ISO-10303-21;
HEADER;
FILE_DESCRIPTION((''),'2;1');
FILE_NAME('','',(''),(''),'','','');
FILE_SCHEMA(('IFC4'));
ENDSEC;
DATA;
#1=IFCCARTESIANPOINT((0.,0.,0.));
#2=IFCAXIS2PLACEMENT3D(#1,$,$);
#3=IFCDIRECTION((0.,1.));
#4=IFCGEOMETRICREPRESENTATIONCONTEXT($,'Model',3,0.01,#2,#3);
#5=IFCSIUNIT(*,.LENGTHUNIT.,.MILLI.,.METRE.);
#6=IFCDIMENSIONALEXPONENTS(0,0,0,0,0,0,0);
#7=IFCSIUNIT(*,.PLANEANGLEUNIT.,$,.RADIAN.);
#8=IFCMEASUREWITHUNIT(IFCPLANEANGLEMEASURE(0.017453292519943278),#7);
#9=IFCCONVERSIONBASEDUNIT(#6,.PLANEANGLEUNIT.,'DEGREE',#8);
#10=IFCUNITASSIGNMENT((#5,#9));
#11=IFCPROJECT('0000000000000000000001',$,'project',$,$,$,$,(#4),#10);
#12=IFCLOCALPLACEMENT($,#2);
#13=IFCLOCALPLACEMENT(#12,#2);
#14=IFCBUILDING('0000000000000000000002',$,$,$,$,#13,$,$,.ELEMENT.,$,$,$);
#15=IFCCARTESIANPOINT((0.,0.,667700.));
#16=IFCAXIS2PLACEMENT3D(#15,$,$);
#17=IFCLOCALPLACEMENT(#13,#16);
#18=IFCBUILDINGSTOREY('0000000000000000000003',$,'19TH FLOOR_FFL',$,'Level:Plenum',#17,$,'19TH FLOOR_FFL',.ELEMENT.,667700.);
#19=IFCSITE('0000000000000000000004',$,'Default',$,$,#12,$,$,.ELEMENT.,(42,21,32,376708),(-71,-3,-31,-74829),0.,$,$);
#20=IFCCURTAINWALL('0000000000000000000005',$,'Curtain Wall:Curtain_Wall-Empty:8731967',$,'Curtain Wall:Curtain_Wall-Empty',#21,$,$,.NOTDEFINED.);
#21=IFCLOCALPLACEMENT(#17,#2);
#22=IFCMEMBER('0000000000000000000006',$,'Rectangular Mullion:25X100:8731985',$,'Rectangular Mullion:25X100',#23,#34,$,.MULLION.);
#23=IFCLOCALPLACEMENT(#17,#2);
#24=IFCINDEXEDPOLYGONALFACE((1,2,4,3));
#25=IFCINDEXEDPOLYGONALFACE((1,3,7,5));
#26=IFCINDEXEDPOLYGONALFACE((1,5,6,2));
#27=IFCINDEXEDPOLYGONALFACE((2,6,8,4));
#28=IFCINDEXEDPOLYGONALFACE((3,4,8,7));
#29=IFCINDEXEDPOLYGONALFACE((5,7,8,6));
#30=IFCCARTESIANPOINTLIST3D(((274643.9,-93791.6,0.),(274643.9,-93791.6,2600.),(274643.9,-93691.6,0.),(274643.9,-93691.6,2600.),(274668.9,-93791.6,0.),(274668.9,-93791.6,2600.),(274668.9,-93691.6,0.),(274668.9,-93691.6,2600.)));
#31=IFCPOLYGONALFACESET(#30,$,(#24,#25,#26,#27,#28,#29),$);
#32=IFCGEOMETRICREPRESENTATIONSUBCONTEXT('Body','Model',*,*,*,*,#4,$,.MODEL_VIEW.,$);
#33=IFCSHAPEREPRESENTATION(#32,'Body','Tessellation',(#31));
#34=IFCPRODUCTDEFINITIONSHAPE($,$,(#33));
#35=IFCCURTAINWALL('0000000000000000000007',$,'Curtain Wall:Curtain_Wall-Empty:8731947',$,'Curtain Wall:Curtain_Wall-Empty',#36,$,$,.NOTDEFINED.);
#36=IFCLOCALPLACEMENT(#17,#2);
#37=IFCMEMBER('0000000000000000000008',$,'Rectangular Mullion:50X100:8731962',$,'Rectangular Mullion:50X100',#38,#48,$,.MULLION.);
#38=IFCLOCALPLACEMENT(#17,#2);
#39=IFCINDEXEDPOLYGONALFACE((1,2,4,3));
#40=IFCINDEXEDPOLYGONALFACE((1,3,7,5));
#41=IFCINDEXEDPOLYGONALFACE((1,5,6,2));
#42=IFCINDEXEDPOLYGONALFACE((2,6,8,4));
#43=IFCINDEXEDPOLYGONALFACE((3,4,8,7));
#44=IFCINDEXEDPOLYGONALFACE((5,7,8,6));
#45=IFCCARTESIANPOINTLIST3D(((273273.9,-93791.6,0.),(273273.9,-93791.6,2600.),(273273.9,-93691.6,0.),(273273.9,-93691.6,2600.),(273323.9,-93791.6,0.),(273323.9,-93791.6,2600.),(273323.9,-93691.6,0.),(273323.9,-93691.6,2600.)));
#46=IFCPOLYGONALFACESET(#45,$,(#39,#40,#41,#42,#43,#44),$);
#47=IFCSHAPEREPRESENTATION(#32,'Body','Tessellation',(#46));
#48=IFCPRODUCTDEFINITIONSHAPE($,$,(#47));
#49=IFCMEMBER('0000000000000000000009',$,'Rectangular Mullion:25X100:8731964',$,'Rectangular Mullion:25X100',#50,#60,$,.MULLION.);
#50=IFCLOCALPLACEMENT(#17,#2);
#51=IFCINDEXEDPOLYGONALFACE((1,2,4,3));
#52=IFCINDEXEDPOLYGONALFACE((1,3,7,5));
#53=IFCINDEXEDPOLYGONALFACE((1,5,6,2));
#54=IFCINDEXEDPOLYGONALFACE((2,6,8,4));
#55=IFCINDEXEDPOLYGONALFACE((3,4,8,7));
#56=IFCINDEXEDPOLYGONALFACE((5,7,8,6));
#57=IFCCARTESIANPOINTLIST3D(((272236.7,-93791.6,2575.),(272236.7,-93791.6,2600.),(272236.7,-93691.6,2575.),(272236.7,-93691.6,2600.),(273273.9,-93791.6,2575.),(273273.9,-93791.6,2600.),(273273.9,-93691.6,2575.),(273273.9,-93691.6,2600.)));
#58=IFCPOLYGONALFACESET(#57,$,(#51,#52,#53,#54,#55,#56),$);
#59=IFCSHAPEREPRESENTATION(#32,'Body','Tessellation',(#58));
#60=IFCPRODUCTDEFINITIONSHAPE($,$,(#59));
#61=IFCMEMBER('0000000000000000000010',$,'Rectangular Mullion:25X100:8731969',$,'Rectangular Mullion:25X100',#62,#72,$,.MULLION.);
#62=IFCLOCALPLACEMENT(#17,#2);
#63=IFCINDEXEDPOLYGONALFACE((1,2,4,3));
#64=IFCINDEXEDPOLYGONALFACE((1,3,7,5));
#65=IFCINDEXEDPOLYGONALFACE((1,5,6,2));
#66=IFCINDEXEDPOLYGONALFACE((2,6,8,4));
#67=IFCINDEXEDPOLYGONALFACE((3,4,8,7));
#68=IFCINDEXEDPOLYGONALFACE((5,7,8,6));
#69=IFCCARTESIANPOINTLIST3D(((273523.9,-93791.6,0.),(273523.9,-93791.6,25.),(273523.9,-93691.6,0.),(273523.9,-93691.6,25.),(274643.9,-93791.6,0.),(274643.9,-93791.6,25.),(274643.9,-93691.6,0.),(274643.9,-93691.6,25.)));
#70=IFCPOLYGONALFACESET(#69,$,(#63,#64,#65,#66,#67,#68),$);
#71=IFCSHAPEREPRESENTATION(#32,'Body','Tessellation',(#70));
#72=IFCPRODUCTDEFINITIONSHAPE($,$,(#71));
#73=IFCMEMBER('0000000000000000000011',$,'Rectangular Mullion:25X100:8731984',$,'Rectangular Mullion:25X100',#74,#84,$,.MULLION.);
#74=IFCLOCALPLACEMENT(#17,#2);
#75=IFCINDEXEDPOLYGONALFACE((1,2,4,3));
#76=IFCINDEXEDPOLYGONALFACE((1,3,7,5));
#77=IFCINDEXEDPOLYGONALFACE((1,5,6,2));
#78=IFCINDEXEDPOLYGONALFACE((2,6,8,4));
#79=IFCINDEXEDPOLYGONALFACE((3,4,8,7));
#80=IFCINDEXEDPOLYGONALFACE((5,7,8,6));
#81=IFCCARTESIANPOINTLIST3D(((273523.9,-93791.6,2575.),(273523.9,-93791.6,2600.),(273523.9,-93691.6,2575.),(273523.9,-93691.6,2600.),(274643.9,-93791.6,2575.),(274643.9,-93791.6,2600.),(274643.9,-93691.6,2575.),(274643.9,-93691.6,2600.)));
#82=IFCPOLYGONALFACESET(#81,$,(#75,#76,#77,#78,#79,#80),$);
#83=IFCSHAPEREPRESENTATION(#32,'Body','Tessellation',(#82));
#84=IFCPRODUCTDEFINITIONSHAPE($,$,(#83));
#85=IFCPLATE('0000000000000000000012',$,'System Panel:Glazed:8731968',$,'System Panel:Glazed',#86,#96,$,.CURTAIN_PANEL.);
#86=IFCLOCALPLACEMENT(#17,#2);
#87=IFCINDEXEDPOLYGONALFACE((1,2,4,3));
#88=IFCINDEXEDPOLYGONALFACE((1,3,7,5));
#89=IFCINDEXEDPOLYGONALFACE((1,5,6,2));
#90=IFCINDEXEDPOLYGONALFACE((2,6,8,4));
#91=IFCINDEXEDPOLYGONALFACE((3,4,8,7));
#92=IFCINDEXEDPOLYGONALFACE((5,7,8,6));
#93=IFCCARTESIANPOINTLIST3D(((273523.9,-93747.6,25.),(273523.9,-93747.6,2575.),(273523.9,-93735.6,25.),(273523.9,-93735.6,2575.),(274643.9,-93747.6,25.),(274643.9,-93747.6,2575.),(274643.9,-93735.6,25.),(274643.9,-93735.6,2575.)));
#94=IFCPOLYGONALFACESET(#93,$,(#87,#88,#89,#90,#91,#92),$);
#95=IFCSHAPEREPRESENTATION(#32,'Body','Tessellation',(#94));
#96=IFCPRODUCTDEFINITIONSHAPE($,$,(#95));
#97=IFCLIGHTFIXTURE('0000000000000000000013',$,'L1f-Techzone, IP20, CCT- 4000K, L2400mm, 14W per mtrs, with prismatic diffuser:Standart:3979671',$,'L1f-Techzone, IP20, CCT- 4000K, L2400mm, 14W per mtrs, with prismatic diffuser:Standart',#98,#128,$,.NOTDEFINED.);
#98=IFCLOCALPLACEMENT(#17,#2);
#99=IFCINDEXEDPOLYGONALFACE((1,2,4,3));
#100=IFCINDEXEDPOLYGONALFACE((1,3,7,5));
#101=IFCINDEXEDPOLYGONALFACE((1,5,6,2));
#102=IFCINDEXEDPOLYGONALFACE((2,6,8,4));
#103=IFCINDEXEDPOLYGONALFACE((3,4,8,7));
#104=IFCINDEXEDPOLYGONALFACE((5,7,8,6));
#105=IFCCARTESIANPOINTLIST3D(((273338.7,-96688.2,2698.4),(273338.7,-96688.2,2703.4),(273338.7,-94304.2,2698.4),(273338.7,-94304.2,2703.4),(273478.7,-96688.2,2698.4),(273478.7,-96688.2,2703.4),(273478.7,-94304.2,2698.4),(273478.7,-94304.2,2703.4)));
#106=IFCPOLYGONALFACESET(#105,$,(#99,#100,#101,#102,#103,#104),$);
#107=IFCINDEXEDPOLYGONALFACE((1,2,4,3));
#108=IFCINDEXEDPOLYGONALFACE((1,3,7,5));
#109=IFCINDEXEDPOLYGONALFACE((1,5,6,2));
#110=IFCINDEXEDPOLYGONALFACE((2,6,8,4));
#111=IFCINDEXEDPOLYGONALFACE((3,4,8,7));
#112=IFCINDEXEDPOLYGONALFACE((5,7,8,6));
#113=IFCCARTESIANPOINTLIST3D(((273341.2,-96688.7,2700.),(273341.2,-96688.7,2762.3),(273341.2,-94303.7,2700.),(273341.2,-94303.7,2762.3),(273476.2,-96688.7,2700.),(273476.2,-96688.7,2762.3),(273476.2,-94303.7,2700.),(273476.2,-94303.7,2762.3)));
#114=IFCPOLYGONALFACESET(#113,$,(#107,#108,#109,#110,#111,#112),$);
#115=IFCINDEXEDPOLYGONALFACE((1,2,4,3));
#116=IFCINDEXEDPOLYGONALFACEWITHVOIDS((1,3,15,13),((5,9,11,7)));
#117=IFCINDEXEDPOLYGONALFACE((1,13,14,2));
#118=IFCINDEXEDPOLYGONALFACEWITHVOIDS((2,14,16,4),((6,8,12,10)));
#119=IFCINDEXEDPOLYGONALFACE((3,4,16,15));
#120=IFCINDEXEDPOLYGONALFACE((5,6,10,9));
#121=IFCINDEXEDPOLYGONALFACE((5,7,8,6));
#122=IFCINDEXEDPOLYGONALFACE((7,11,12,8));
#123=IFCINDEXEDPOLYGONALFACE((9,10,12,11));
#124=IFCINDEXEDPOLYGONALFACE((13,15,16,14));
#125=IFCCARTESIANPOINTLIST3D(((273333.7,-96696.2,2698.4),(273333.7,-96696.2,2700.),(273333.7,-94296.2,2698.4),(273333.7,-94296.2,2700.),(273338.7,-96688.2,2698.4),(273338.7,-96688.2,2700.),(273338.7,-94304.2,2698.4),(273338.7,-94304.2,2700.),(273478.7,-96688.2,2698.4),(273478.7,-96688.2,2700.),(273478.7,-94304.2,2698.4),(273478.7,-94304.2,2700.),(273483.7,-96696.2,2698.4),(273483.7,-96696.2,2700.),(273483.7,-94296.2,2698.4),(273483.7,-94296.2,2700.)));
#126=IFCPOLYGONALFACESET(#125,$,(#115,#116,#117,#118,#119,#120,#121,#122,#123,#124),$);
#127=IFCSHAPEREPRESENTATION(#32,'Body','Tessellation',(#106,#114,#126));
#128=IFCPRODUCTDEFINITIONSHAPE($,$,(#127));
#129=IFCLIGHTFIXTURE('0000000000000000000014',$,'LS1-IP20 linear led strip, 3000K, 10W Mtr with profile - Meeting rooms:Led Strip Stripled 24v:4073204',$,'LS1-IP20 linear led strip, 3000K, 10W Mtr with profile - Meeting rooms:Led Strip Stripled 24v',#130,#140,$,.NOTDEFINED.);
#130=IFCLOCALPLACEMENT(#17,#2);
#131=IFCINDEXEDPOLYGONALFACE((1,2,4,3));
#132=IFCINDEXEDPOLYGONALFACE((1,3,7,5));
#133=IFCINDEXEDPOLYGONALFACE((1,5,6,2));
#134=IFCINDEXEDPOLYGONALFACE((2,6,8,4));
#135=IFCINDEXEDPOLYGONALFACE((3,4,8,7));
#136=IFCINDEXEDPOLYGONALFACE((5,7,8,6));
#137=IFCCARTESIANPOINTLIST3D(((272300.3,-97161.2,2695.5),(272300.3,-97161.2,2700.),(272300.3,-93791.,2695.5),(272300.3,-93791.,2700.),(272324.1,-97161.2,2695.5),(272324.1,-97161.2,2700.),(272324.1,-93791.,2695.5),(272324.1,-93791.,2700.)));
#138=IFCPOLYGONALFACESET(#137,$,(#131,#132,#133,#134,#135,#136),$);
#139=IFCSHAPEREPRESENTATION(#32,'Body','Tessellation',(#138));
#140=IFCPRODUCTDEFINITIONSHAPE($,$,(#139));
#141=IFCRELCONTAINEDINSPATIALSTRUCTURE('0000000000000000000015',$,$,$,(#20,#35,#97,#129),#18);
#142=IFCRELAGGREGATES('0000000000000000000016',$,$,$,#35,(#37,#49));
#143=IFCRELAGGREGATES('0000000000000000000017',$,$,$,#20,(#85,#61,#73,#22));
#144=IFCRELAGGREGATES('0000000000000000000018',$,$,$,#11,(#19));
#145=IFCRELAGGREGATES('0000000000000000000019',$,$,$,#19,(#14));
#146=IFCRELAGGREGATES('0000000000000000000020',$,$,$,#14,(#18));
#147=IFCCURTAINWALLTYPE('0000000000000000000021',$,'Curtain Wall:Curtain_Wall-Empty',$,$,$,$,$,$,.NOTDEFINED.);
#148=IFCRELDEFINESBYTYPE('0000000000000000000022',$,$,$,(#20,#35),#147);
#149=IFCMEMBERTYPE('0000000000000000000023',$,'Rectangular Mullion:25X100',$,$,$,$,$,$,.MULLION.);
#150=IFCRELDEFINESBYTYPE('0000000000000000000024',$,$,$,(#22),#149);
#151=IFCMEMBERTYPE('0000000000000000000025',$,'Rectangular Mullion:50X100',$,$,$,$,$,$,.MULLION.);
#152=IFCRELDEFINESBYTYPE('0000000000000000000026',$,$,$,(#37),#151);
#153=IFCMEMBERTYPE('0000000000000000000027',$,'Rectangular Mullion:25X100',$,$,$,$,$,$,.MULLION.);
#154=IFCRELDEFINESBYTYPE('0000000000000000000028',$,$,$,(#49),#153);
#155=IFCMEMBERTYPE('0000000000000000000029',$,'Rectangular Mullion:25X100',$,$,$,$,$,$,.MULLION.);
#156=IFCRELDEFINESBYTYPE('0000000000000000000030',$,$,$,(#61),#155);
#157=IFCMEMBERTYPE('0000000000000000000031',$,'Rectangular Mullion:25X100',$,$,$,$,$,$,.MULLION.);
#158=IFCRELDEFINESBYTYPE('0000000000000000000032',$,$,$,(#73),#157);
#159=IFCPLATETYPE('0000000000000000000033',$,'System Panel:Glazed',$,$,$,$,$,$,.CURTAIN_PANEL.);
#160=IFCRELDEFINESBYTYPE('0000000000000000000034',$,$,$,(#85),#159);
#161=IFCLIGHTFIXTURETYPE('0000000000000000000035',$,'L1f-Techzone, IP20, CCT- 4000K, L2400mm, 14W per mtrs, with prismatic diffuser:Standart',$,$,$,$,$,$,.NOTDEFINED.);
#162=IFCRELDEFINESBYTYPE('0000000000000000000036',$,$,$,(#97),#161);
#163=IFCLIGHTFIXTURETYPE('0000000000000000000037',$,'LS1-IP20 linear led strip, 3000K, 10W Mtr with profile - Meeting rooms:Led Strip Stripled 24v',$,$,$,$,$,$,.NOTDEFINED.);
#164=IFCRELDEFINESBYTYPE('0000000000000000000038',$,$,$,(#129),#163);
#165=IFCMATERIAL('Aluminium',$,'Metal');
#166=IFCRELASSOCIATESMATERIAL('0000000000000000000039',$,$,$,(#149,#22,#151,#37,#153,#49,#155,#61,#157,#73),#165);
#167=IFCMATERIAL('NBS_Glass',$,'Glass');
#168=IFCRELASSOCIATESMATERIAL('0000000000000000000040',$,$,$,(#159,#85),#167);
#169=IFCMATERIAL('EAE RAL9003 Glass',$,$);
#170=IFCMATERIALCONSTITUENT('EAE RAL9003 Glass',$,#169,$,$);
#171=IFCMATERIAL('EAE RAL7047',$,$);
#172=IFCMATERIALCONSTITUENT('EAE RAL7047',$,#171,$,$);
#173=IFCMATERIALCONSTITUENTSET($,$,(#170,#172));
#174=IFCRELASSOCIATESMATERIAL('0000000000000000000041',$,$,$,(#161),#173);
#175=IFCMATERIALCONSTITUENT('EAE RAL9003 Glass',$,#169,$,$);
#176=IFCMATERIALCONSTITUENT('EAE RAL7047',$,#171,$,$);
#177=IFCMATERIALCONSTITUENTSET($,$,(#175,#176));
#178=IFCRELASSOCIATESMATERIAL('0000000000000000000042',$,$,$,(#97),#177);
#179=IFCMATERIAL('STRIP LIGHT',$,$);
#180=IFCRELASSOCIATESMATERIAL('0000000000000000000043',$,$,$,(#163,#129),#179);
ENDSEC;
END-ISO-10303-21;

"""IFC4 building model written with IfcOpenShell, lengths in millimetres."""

from ifc_helpers import new_model, entity, si_unit, converted_unit, direction, frame, origin, place, context, subcontext, project, spatial, indexed_curve, outline, extrude, source, transform, mapped, material, constituent, constituent_set, type_object, type_shapes, element, aggregate, save


model = new_model("IFC4")

# Units and contexts
model_context = context("Model", 3, precision=0.01, world=origin(), true_north=direction((0.0, 1.0)))
body_context = subcontext(model_context, "Body", "Model", "MODEL_VIEW")
ifc_project = project(units=[si_unit("LENGTHUNIT", "METRE", prefix="MILLI"), converted_unit("PLANEANGLEUNIT", "DEGREE", entity("IfcPlaneAngleMeasure", 0.017453292519943278), si_unit("PLANEANGLEUNIT", "RADIAN"), dimensions=[0, 0, 0, 0, 0, 0, 0])], contexts=[model_context])

# Site, building, storey
site_placement = place(None, origin())
site = spatial("IfcSite", under=ifc_project, at=site_placement, Name="Default", CompositionType="ELEMENT", RefLatitude=(42, 21, 32, 376708), RefLongitude=(-71, -3, -31, -74829), RefElevation=0.0)
building_placement = place(site_placement, origin())
building = spatial("IfcBuilding", under=site, at=building_placement, CompositionType="ELEMENT")
storey_placement = place(building_placement, frame((0.0, 0.0, 667700.0)))
storey = spatial("IfcBuildingStorey", under=building, at=storey_placement, Name="19TH FLOOR_FFL", ObjectType="Level:Plenum", LongName="19TH FLOOR_FFL", CompositionType="ELEMENT", Elevation=667700.0)

# Curtain wall, member
curtain_wall_type = type_object("IfcCurtainWallType", Name="Curtain Wall:Curtain_Wall-Empty", PredefinedType="NOTDEFINED")
curtain_wall_1_placement = place(storey_placement, frame((0.0, 0.0, -667700.0)))
curtain_wall_1 = element("IfcCurtainWall", 1, at=curtain_wall_1_placement, inside=storey, type_object=curtain_wall_type, Name="Curtain Wall:Curtain_Wall-Empty:8731967", ObjectType="Curtain Wall:Curtain_Wall-Empty", PredefinedType="NOTDEFINED")
ifc_material_1 = material(Name="Aluminium", Category="Metal")
member_type_1 = type_object("IfcMemberType", Name="Rectangular Mullion:25X100", PredefinedType="MULLION", material=ifc_material_1)
shared_shape_1 = source(origin(), body_context, "Body", "SweptSolid", [
    extrude(outline(indexed_curve([(-12.5, -50.0), (12.5, -50.0), (12.5, 50.0), (-12.5, 50.0), (-12.5, -50.0)], self_intersect=False)), frame((-12.5, 0.0, -2600.0), z_axis=(0.0, 0.0, 1.0), x_axis=(-1.0, 0.0, 0.0)), (0.0, 0.0, 1.0), 2600.0),
])
type_shapes(member_type_1, [shared_shape_1])
member_1_placement = place(curtain_wall_1_placement, frame((274668.9, -93741.6, 670300.0)))
member_1 = element("IfcMember", 2, at=member_1_placement, type_object=member_type_1, material=ifc_material_1, Name="Rectangular Mullion:25X100:8731985", ObjectType="Rectangular Mullion:25X100", PredefinedType="MULLION", context=body_context, shape_type="MappedRepresentation", body=[
    mapped(shared_shape_1, transform((0.0, 0.0, 0.0), scale=1.0)),
])

# Curtain wall, members
curtain_wall_2_placement = place(storey_placement, frame((0.0, 0.0, -667700.0)))
curtain_wall_2 = element("IfcCurtainWall", 3, at=curtain_wall_2_placement, inside=storey, type_object=curtain_wall_type, Name="Curtain Wall:Curtain_Wall-Empty:8731947", ObjectType="Curtain Wall:Curtain_Wall-Empty", PredefinedType="NOTDEFINED")
member_type_2 = type_object("IfcMemberType", Name="Rectangular Mullion:50X100", PredefinedType="MULLION", material=ifc_material_1)
shared_shape_2 = source(origin(), body_context, "Body", "SweptSolid", [
    extrude(outline(indexed_curve([(-25.0, -50.0), (25.0, -50.0), (25.0, 50.0), (-25.0, 50.0), (-25.0, -50.0)], self_intersect=False)), frame((-25.0, 0.0, -2600.0), z_axis=(0.0, 0.0, 1.0), x_axis=(-1.0, 0.0, 0.0)), (0.0, 0.0, 1.0), 2600.0),
])
type_shapes(member_type_2, [shared_shape_2])
member_2_placement = place(curtain_wall_2_placement, frame((273323.9, -93741.6, 670300.0)))
member_2 = element("IfcMember", 4, at=member_2_placement, type_object=member_type_2, material=ifc_material_1, Name="Rectangular Mullion:50X100:8731962", ObjectType="Rectangular Mullion:50X100", PredefinedType="MULLION", context=body_context, shape_type="MappedRepresentation", body=[
    mapped(shared_shape_2, transform((0.0, 0.0, 0.0), scale=1.0)),
])
member_type_3 = type_object("IfcMemberType", Name="Rectangular Mullion:25X100", PredefinedType="MULLION", material=ifc_material_1)
shared_shape_3 = source(origin(), body_context, "Body", "SweptSolid", [
    extrude(outline(indexed_curve([(-12.5, -50.0), (12.5, -50.0), (12.5, 50.0), (-12.5, 50.0), (-12.5, -50.0)], self_intersect=False)), frame((-12.5, 0.0, -1037.2), z_axis=(0.0, 0.0, 1.0), x_axis=(-1.0, 0.0, 0.0)), (0.0, 0.0, 1.0), 1037.2),
])
type_shapes(member_type_3, [shared_shape_3])
member_3_placement = place(curtain_wall_2_placement, frame((272236.7, -93741.6, 670300.0), z_axis=(-1.0, 0.0, 0.0), x_axis=(0.0, 0.0, 1.0)))
member_3 = element("IfcMember", 5, at=member_3_placement, type_object=member_type_3, material=ifc_material_1, Name="Rectangular Mullion:25X100:8731964", ObjectType="Rectangular Mullion:25X100", PredefinedType="MULLION", context=body_context, shape_type="MappedRepresentation", body=[
    mapped(shared_shape_3, transform((0.0, 0.0, 0.0), scale=1.0)),
])
aggregate(curtain_wall_2, [member_2, member_3])

# Members
member_type_4 = type_object("IfcMemberType", Name="Rectangular Mullion:25X100", PredefinedType="MULLION", material=ifc_material_1)
shared_shape_4 = source(origin(), body_context, "Body", "SweptSolid", [
    extrude(outline(indexed_curve([(-12.5, -50.0), (12.5, -50.0), (12.5, 50.0), (-12.5, 50.0), (-12.5, -50.0)], self_intersect=False)), frame((-12.5, 0.0, -1120.0), z_axis=(0.0, 0.0, 1.0), x_axis=(-1.0, 0.0, 0.0)), (0.0, 0.0, 1.0), 1120.0),
])
type_shapes(member_type_4, [shared_shape_4])
member_4_placement = place(curtain_wall_1_placement, frame((274643.9, -93741.6, 667700.0), z_axis=(1.0, 0.0, 0.0), x_axis=(0.0, 0.0, -1.0)))
member_4 = element("IfcMember", 6, at=member_4_placement, type_object=member_type_4, material=ifc_material_1, Name="Rectangular Mullion:25X100:8731969", ObjectType="Rectangular Mullion:25X100", PredefinedType="MULLION", context=body_context, shape_type="MappedRepresentation", body=[
    mapped(shared_shape_4, transform((0.0, 0.0, 0.0), scale=1.0)),
])
member_type_5 = type_object("IfcMemberType", Name="Rectangular Mullion:25X100", PredefinedType="MULLION", material=ifc_material_1)
shared_shape_5 = source(origin(), body_context, "Body", "SweptSolid", [
    extrude(outline(indexed_curve([(-12.5, -50.0), (12.5, -50.0), (12.5, 50.0), (-12.5, 50.0), (-12.5, -50.0)], self_intersect=False)), frame((-12.5, 0.0, -1120.0), z_axis=(0.0, 0.0, 1.0), x_axis=(-1.0, 0.0, 0.0)), (0.0, 0.0, 1.0), 1120.0),
])
type_shapes(member_type_5, [shared_shape_5])
member_5_placement = place(curtain_wall_1_placement, frame((273523.9, -93741.6, 670300.0), z_axis=(-1.0, 0.0, 0.0), x_axis=(0.0, 0.0, 1.0)))
member_5 = element("IfcMember", 7, at=member_5_placement, type_object=member_type_5, material=ifc_material_1, Name="Rectangular Mullion:25X100:8731984", ObjectType="Rectangular Mullion:25X100", PredefinedType="MULLION", context=body_context, shape_type="MappedRepresentation", body=[
    mapped(shared_shape_5, transform((0.0, 0.0, 0.0), scale=1.0)),
])

# Plate
ifc_material_2 = material(Name="NBS_Glass", Category="Glass")
plate_type = type_object("IfcPlateType", Name="System Panel:Glazed", PredefinedType="CURTAIN_PANEL", material=ifc_material_2)
shared_shape_6 = source(origin(), body_context, "Body", "SweptSolid", [
    extrude(outline(indexed_curve([(-6.0, -560.0), (6.0, -560.0), (6.0, 560.0), (-6.0, 560.0), (-6.0, -560.0)], self_intersect=False)), frame((0.0, 0.0, 0.0), z_axis=(0.0, 0.0, 1.0), x_axis=(0.0, 1.0, 0.0)), (0.0, 0.0, 1.0), 2550.0),
])
type_shapes(plate_type, [shared_shape_6])
plate_placement = place(curtain_wall_1_placement, frame((274083.9, -93741.6, 667725.0), z_axis=(0.0, 0.0, 1.0), x_axis=(-1.0, 0.0, 0.0)))
plate = element("IfcPlate", 8, at=plate_placement, type_object=plate_type, material=ifc_material_2, Name="System Panel:Glazed:8731968", ObjectType="System Panel:Glazed", PredefinedType="CURTAIN_PANEL", context=body_context, shape_type="MappedRepresentation", body=[
    mapped(shared_shape_6, transform((0.0, 0.0, 0.0), scale=1.0)),
])
aggregate(curtain_wall_1, [plate, member_4, member_5, member_1])

# Light fixtures
ifc_material_3 = material(Name="EAE RAL9003 Glass")
ifc_constituent_1 = constituent(ifc_material_3, Name="EAE RAL9003 Glass")
ifc_material_4 = material(Name="EAE RAL7047")
ifc_constituent_2 = constituent(ifc_material_4, Name="EAE RAL7047")
ifc_constituent_set_1 = constituent_set(constituents=[ifc_constituent_1, ifc_constituent_2])
ifc_constituent_3 = constituent(ifc_material_3, Name="EAE RAL9003 Glass")
ifc_constituent_4 = constituent(ifc_material_4, Name="EAE RAL7047")
ifc_constituent_set_2 = constituent_set(constituents=[ifc_constituent_3, ifc_constituent_4])
light_fixture_type_1 = type_object("IfcLightFixtureType", Name="L1f-Techzone, IP20, CCT- 4000K, L2400mm, 14W per mtrs, with prismatic diffuser:Standart", PredefinedType="NOTDEFINED", material=ifc_constituent_set_2)
shared_shape_7 = source(origin(), body_context, "Body", "SweptSolid", [
    extrude(outline(indexed_curve([(-70.0, -1192.0), (70.0, -1192.0), (70.0, 1192.0), (-70.0, 1192.0), (-70.0, -1192.0)], self_intersect=False)), frame((0.0, 0.0, -3.4), z_axis=(0.0, 0.0, 1.0), x_axis=(-1.0, 0.0, 0.0)), (0.0, 0.0, 1.0), 5.0),
    extrude(outline(indexed_curve([(-67.5, -1192.5), (67.5, -1192.5), (67.5, 1192.5), (-67.5, 1192.5), (-67.5, -1192.5)], self_intersect=False)), frame((0.0, 0.0, -62.3), z_axis=(0.0, 0.0, 1.0), x_axis=(-1.0, 0.0, 0.0)), (0.0, 0.0, 1.0), 62.3),
    extrude(outline(indexed_curve([(-75.0, -1200.0), (75.0, -1200.0), (75.0, 1200.0), (-75.0, 1200.0), (-75.0, -1200.0)], self_intersect=False), holes=[indexed_curve([(-70.0, -1192.0), (-70.0, 1192.0), (70.0, 1192.0), (70.0, -1192.0), (-70.0, -1192.0)], self_intersect=False)]), frame((0.0, 0.0, 0.0), z_axis=(0.0, 0.0, 1.0), x_axis=(-1.0, 0.0, 0.0)), (0.0, 0.0, 1.0), 1.6),
])
type_shapes(light_fixture_type_1, [shared_shape_7])
light_fixture_1_placement = place(storey_placement, frame((273408.7, -95496.2, 2700.0), z_axis=(0.0, 0.0, -1.0), x_axis=(-1.0, 0.0, 0.0)))
element("IfcLightFixture", 9, at=light_fixture_1_placement, inside=storey, type_object=light_fixture_type_1, material=ifc_constituent_set_1, Name="L1f-Techzone, IP20, CCT- 4000K, L2400mm, 14W per mtrs, with prismatic diffuser:Standart:3979671", ObjectType="L1f-Techzone, IP20, CCT- 4000K, L2400mm, 14W per mtrs, with prismatic diffuser:Standart", PredefinedType="NOTDEFINED", context=body_context, shape_type="MappedRepresentation", body=[
    mapped(shared_shape_7, transform((0.0, 0.0, 0.0), scale=1.0)),
])
ifc_material_5 = material(Name="STRIP LIGHT")
light_fixture_type_2 = type_object("IfcLightFixtureType", Name="LS1-IP20 linear led strip, 3000K, 10W Mtr with profile - Meeting rooms:Led Strip Stripled 24v", PredefinedType="NOTDEFINED", material=ifc_material_5)
shared_shape_8 = source(origin(), body_context, "Body", "SweptSolid", [
    extrude(outline(indexed_curve([(-11.9, -1685.1), (11.9, -1685.1), (11.9, 1685.1), (-11.9, 1685.1), (-11.9, -1685.1)], self_intersect=False)), frame((0.0, 0.3, 0.0), z_axis=(0.0, 0.0, 1.0), x_axis=(0.0, -1.0, 0.0)), (0.0, 0.0, 1.0), 4.5),
])
type_shapes(light_fixture_type_2, [shared_shape_8])
light_fixture_2_placement = place(storey_placement, frame((272312.6, -95476.1, 2700.0), z_axis=(0.0, 0.0, -1.0), x_axis=(0.0, -1.0, 0.0)))
element("IfcLightFixture", 10, at=light_fixture_2_placement, inside=storey, type_object=light_fixture_type_2, material=ifc_material_5, Name="LS1-IP20 linear led strip, 3000K, 10W Mtr with profile - Meeting rooms:Led Strip Stripled 24v:4073204", ObjectType="LS1-IP20 linear led strip, 3000K, 10W Mtr with profile - Meeting rooms:Led Strip Stripled 24v", PredefinedType="NOTDEFINED", context=body_context, shape_type="MappedRepresentation", body=[
    mapped(shared_shape_8, transform((0.0, 0.0, 0.0), scale=1.0)),
])

save(model, "model.ifc")
